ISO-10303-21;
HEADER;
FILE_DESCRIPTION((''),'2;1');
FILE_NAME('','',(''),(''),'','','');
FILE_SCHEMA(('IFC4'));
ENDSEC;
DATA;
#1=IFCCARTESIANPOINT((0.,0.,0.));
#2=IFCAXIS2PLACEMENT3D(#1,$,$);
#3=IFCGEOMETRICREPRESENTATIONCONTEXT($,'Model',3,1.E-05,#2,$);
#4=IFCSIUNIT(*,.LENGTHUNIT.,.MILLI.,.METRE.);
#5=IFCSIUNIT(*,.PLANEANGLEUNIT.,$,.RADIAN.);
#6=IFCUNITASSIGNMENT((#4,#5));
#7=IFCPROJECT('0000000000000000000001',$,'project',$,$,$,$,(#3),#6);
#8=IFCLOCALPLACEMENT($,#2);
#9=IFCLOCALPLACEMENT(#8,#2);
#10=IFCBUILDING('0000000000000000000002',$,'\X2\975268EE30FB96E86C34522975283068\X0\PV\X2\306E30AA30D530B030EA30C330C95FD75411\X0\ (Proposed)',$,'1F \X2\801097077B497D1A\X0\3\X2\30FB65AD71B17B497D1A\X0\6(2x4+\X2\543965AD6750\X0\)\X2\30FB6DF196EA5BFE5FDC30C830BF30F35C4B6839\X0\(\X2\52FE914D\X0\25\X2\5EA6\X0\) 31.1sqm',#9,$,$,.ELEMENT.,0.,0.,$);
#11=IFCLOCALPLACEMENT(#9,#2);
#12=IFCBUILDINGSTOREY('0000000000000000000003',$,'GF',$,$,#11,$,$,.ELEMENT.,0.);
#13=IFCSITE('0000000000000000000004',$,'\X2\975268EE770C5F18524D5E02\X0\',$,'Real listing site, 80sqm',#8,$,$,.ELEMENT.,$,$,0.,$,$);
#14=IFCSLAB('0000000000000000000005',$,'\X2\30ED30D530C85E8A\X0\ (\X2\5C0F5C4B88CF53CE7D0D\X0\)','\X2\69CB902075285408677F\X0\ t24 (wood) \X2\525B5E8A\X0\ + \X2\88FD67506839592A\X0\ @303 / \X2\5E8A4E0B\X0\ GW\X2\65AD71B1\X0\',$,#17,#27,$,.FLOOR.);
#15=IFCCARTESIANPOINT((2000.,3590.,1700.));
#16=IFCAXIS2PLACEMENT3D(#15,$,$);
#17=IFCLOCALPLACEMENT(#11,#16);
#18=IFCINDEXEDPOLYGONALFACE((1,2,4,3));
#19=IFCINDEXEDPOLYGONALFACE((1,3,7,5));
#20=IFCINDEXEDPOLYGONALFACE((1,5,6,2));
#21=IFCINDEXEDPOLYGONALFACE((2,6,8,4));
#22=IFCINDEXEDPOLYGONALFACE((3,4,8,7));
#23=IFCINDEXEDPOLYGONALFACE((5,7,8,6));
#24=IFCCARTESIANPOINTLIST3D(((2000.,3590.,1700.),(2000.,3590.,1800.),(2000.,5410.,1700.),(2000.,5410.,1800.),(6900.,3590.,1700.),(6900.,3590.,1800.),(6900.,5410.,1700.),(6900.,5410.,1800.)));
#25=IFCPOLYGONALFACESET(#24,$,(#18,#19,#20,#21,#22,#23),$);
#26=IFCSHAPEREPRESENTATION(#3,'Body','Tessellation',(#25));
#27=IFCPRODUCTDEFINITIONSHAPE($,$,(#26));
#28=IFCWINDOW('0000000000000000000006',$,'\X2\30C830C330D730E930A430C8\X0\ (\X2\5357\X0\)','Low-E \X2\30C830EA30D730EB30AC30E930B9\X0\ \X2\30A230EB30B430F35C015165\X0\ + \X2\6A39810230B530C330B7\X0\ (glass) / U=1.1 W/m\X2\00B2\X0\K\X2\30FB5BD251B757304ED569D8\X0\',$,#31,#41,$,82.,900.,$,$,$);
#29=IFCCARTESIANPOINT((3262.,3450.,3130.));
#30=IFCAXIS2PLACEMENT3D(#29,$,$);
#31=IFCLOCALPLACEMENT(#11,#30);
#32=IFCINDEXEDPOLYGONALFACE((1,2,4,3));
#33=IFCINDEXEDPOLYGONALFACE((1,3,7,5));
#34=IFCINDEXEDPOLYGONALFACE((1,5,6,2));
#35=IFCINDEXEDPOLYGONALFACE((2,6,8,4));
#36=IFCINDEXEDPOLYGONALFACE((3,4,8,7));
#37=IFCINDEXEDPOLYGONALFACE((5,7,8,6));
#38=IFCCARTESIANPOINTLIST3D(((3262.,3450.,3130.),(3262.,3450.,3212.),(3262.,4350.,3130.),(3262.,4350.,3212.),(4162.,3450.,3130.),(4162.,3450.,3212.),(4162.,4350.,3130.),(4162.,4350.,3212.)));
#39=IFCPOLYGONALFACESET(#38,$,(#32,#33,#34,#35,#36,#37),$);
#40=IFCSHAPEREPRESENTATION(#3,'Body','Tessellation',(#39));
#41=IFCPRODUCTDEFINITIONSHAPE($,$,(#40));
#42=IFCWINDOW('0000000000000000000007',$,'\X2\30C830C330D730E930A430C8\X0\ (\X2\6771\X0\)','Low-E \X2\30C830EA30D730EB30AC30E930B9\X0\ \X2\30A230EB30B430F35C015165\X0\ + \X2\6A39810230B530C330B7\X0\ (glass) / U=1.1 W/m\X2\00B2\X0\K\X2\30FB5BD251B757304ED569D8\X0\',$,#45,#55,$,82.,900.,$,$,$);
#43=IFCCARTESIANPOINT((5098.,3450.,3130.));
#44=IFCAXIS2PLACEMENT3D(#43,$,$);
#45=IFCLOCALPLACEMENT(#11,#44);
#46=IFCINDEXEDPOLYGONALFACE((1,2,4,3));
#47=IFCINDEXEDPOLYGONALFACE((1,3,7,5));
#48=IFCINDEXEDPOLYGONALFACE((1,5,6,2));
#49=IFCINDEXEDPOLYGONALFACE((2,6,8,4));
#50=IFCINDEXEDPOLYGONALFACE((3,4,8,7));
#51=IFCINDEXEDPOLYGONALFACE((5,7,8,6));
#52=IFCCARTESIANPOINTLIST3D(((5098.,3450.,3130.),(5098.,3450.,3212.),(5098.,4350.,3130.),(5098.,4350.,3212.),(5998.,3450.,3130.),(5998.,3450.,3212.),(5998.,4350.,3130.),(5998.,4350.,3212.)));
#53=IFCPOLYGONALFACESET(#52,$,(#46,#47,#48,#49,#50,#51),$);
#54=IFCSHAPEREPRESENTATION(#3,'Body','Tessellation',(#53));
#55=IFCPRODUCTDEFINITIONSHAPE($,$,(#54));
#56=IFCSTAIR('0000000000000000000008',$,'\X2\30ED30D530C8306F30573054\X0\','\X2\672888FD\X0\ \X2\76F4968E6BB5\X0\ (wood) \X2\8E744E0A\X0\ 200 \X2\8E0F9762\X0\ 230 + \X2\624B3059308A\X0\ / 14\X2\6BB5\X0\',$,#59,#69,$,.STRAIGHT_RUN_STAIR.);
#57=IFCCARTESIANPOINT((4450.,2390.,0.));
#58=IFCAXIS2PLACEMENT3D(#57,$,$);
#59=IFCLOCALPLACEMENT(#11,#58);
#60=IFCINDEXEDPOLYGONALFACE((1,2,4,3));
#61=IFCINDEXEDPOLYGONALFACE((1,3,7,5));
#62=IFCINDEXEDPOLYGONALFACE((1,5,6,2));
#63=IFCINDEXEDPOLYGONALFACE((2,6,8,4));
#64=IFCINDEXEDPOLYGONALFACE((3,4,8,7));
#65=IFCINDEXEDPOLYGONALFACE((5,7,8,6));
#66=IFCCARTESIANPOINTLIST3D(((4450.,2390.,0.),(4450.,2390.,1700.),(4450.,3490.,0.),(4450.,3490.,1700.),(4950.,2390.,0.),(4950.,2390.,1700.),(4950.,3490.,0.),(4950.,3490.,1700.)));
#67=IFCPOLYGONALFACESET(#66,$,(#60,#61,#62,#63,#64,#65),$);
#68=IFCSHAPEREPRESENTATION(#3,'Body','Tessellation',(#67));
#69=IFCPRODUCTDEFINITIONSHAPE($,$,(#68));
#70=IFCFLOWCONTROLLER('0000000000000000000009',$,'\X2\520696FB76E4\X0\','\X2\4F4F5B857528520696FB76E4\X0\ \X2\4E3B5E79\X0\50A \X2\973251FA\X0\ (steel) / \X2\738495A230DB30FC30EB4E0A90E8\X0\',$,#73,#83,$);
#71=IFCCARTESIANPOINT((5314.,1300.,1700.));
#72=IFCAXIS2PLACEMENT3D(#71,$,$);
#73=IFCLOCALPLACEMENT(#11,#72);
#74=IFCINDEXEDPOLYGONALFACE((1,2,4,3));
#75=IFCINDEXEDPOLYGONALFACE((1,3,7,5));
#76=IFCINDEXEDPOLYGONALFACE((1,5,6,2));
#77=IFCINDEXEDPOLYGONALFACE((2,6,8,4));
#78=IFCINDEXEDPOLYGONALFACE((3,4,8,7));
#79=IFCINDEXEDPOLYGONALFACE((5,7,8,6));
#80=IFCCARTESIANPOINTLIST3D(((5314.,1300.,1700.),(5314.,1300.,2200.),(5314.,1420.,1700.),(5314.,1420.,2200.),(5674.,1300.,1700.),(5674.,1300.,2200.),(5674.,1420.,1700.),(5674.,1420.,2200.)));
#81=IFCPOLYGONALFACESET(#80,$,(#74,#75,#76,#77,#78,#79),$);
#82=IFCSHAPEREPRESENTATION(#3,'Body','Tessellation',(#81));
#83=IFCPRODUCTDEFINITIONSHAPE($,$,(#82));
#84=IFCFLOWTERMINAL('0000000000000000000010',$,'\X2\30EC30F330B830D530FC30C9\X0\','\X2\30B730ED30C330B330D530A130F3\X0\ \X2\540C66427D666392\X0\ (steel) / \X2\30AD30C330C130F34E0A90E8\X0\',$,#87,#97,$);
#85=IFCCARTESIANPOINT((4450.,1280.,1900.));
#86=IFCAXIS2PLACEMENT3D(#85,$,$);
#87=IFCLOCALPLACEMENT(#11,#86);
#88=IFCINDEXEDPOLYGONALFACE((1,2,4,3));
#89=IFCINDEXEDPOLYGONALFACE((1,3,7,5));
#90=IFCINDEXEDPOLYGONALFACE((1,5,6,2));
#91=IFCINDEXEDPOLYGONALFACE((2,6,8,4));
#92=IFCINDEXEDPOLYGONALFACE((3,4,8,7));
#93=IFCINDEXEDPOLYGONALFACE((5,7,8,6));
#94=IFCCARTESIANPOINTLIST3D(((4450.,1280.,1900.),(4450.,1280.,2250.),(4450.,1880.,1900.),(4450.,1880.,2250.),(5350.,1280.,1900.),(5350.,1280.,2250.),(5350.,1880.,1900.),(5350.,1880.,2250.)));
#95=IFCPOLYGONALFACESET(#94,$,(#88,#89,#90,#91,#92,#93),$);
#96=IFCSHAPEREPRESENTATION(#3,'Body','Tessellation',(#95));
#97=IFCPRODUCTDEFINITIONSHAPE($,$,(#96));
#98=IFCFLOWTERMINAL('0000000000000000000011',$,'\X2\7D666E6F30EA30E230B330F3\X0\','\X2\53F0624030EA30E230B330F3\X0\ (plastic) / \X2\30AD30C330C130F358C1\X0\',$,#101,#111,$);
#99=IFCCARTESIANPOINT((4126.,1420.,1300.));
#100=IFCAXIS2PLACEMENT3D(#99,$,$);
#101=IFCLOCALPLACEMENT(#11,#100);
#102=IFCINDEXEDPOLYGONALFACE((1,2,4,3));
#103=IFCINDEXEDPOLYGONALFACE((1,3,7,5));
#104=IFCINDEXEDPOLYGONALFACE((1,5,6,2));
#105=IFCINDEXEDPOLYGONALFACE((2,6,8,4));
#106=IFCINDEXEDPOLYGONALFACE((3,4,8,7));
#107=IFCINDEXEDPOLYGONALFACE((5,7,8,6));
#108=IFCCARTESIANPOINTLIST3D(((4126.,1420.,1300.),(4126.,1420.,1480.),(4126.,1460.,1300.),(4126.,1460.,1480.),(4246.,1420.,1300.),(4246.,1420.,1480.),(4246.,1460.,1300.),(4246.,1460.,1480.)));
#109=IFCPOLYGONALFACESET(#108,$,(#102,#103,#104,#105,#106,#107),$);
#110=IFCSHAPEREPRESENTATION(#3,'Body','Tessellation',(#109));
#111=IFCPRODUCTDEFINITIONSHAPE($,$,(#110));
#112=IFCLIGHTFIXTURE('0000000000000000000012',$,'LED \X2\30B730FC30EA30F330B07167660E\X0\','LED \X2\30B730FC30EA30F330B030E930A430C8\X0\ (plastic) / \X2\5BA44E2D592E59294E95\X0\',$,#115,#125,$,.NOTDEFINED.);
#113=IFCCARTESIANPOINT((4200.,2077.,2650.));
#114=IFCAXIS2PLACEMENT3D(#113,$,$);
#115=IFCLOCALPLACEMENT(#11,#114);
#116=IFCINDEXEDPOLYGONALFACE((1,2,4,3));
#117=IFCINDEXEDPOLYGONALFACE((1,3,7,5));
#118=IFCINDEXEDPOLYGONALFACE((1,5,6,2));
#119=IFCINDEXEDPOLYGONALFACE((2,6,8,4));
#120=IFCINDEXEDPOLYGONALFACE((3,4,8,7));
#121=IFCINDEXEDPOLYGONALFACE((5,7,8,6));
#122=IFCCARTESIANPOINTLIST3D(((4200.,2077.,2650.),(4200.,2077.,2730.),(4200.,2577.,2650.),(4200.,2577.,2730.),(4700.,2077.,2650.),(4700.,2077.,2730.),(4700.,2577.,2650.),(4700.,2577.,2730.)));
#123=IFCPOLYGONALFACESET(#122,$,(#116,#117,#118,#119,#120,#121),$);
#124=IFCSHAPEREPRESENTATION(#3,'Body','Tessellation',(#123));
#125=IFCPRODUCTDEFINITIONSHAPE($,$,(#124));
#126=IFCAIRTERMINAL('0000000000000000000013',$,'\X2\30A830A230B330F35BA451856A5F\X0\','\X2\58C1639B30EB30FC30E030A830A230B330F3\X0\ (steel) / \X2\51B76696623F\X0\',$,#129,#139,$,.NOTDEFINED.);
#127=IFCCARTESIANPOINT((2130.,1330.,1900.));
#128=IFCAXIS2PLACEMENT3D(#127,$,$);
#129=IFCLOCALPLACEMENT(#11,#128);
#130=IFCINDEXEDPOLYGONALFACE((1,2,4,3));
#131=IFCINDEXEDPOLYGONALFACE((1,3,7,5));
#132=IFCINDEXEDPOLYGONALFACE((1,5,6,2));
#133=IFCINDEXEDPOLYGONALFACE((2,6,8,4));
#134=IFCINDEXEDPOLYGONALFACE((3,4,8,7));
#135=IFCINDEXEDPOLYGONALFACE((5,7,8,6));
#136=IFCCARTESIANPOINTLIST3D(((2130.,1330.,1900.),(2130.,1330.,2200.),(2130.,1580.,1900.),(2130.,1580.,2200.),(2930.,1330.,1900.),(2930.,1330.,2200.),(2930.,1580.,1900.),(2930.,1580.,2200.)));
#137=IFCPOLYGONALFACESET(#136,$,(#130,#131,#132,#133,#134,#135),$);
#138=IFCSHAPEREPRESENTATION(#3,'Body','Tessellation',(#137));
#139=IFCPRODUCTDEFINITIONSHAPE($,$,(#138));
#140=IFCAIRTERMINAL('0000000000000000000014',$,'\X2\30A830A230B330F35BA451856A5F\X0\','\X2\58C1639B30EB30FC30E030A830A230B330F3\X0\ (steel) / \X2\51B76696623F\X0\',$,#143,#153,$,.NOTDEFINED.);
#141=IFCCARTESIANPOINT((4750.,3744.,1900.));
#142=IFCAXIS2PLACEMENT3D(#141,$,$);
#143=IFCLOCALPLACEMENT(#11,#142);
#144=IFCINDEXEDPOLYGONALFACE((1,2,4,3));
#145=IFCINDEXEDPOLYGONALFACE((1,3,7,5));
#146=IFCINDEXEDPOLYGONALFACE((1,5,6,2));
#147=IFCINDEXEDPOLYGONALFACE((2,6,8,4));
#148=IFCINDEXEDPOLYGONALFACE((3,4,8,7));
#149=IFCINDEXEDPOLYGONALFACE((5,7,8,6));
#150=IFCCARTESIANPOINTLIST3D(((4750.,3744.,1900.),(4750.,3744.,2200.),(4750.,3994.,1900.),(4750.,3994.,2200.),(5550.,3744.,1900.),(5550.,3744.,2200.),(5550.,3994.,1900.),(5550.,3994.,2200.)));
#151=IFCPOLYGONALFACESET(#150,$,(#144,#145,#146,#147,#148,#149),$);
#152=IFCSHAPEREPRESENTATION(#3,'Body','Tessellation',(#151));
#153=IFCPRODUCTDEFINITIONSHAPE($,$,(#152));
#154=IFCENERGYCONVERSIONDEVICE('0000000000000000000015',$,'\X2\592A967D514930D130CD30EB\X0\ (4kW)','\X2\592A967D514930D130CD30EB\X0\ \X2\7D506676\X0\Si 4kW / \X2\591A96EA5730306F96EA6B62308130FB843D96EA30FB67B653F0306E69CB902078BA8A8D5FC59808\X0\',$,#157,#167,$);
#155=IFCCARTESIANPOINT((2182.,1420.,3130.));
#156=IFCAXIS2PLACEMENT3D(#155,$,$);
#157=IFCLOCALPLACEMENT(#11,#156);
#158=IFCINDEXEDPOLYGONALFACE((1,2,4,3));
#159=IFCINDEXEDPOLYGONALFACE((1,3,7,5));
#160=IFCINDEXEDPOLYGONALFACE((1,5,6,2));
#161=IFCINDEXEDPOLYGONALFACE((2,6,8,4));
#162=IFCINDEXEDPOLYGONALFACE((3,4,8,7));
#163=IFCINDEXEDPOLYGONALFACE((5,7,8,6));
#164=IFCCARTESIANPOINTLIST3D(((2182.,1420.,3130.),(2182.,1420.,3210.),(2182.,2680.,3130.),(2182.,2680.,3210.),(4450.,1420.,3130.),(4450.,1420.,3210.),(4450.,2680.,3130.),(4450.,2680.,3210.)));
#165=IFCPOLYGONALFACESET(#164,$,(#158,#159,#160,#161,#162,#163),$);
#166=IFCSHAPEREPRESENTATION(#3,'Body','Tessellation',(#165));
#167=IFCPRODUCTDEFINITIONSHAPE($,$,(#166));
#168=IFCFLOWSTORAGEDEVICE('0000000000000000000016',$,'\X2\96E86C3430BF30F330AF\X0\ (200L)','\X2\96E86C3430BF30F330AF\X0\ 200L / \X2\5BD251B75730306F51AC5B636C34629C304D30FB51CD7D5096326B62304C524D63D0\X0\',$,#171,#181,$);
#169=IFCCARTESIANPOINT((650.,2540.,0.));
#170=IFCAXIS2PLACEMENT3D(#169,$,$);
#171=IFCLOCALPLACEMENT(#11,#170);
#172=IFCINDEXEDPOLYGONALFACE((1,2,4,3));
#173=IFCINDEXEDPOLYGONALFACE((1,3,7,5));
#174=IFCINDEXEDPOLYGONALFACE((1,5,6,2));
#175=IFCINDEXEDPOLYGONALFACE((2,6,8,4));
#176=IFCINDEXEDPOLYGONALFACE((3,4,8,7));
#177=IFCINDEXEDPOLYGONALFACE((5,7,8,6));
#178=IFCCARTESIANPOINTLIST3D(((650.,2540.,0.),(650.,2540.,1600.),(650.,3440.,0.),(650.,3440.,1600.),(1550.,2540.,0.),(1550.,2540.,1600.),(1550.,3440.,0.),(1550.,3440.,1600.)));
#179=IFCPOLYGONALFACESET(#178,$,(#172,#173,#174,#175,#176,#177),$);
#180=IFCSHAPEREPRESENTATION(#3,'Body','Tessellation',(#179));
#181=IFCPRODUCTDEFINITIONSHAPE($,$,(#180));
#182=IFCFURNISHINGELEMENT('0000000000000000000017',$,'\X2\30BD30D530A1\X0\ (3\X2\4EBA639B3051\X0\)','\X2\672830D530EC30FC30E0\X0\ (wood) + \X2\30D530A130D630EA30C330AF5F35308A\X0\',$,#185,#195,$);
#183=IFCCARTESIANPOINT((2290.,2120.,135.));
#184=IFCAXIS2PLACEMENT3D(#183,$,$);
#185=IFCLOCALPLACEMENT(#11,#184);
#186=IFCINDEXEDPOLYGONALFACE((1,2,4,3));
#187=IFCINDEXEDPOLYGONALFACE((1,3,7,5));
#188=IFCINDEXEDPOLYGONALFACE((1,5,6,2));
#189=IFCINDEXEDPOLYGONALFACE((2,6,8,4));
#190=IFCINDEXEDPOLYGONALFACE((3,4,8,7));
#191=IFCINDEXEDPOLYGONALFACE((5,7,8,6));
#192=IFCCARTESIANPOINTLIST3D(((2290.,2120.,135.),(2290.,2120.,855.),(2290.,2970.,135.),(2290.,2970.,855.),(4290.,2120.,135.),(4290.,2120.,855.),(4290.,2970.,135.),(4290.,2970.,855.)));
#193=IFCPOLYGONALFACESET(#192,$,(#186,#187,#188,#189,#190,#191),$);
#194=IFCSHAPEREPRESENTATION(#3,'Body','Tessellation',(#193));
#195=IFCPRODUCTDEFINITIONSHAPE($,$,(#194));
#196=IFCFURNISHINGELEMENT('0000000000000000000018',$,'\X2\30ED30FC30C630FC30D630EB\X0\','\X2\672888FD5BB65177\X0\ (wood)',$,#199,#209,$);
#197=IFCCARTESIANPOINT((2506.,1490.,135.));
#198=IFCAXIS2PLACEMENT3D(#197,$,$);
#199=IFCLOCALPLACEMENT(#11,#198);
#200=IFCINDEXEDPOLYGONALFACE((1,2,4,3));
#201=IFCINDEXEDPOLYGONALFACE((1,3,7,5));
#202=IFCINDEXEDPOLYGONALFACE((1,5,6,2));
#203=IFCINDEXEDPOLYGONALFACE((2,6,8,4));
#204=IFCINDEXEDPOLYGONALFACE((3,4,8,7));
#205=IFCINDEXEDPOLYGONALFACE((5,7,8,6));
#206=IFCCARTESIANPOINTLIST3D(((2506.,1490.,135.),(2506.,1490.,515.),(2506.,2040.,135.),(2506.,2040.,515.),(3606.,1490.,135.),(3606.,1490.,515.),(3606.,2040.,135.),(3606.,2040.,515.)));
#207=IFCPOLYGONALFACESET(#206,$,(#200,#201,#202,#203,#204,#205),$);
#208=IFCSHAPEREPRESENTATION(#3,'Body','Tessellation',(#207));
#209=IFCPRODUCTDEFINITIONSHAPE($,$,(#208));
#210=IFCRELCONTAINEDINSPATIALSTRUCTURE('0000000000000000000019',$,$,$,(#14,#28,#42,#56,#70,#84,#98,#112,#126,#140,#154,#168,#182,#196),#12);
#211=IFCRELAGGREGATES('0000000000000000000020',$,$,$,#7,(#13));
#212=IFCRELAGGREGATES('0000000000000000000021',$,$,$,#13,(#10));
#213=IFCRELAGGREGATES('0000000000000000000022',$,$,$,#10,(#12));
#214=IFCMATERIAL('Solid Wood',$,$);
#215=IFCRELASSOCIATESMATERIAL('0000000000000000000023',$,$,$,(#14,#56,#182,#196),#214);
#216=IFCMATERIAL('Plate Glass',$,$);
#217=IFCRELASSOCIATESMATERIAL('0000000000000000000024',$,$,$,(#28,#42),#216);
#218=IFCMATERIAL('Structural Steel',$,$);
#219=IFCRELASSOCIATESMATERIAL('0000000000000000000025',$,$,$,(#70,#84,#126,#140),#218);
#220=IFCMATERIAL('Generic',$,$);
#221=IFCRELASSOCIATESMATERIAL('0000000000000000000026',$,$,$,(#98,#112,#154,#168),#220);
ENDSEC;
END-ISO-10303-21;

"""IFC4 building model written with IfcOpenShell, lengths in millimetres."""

from ifc_helpers import new_model, si_unit, frame, frame_2d, origin, place, context, project, spatial, rectangle, extrude, material, element, save


model = new_model("IFC4")

# Units and contexts
model_context = context("Model", 3, precision=1e-05, world=origin())
ifc_project = project(units=[si_unit("LENGTHUNIT", "METRE", prefix="MILLI"), si_unit("PLANEANGLEUNIT", "RADIAN")], contexts=[model_context])

# Site, building, storey
site_placement = place(None, origin())
site = spatial("IfcSite", under=ifc_project, at=site_placement, Name="青森県弘前市", ObjectType="Real listing site, 80sqm", CompositionType="ELEMENT", RefElevation=0.0)
building_placement = place(site_placement, origin())
building = spatial("IfcBuilding", under=site, at=building_placement, Name="青森・雨水利用とPVのオフグリッド志向 (Proposed)", ObjectType="1F 耐震等級3・断熱等級6(2x4+吹断材)・深雪対応トタン屋根(勾配25度) 31.1sqm", CompositionType="ELEMENT", ElevationOfRefHeight=0.0, ElevationOfTerrain=0.0)
storey_placement = place(building_placement, origin())
storey = spatial("IfcBuildingStorey", under=building, at=storey_placement, Name="GF", CompositionType="ELEMENT", Elevation=0.0)

# Shared definitions
ifc_material_1 = material(Name="Solid Wood")

# Slab
slab_placement = place(storey_placement, frame((2000.0, 3590.0, 1700.0)))
element("IfcSlab", 1, at=slab_placement, inside=storey, material=ifc_material_1, Name="ロフト床 (小屋裏収納)", Description="構造用合板 t24 (wood) 剛床 + 製材根太 @303 / 床下 GW断熱", PredefinedType="FLOOR", context=model_context, shape_type="SweptSolid", body=[
    extrude(rectangle(XDim=4900.0, YDim=1820.0, at=frame_2d((2450.0, 910.0))), frame((2000.0, 3590.0, 1700.0)), (0.0, 0.0, 1.0), 100.0),
])

# Windows
ifc_material_2 = material(Name="Plate Glass")
window_1_placement = place(storey_placement, frame((3262.0, 3450.0, 3130.0)))
element("IfcWindow", 2, at=window_1_placement, inside=storey, material=ifc_material_2, Name="トップライト (南)", Description="Low-E トリプルガラス アルゴン封入 + 樹脂サッシ (glass) / U=1.1 W/m²K・寒冷地仕様", OverallHeight=82.0, OverallWidth=900.0, context=model_context, shape_type="SweptSolid", body=[
    extrude(rectangle(XDim=900.0, YDim=900.0, at=frame_2d((450.0, 450.0))), frame((3262.0, 3450.0, 3130.0)), (0.0, 0.0, 1.0), 82.0),
])
window_2_placement = place(storey_placement, frame((5098.0, 3450.0, 3130.0)))
element("IfcWindow", 3, at=window_2_placement, inside=storey, material=ifc_material_2, Name="トップライト (東)", Description="Low-E トリプルガラス アルゴン封入 + 樹脂サッシ (glass) / U=1.1 W/m²K・寒冷地仕様", OverallHeight=82.0, OverallWidth=900.0, context=model_context, shape_type="SweptSolid", body=[
    extrude(rectangle(XDim=900.0, YDim=900.0, at=frame_2d((450.0, 450.0))), frame((5098.0, 3450.0, 3130.0)), (0.0, 0.0, 1.0), 82.0),
])

# Stair
stair_placement = place(storey_placement, frame((4450.0, 2390.0, 0.0)))
element("IfcStair", 4, at=stair_placement, inside=storey, material=ifc_material_1, Name="ロフトはしご", Description="木製 直階段 (wood) 蹴上 200 踏面 230 + 手すり / 14段", PredefinedType="STRAIGHT_RUN_STAIR", context=model_context, shape_type="SweptSolid", body=[
    extrude(rectangle(XDim=500.0, YDim=1100.0, at=frame_2d((250.0, 550.0))), frame((4450.0, 2390.0, 0.0)), (0.0, 0.0, 1.0), 1700.0),
])

# Flow controller
ifc_material_3 = material(Name="Structural Steel")
flow_controller_placement = place(storey_placement, frame((5314.0, 1300.0, 1700.0)))
element("IfcFlowController", 5, at=flow_controller_placement, inside=storey, material=ifc_material_3, Name="分電盤", Description="住宅用分電盤 主幹50A 露出 (steel) / 玄関ホール上部", context=model_context, shape_type="SweptSolid", body=[
    extrude(rectangle(XDim=360.0, YDim=120.0, at=frame_2d((180.0, 60.0))), frame((5314.0, 1300.0, 1700.0)), (0.0, 0.0, 1.0), 500.0),
])

# Flow terminals
flow_terminal_1_placement = place(storey_placement, frame((4450.0, 1280.0, 1900.0)))
element("IfcFlowTerminal", 6, at=flow_terminal_1_placement, inside=storey, material=ifc_material_3, Name="レンジフード", Description="シロッコファン 同時給排 (steel) / キッチン上部", context=model_context, shape_type="SweptSolid", body=[
    extrude(rectangle(XDim=900.0, YDim=600.0, at=frame_2d((450.0, 300.0))), frame((4450.0, 1280.0, 1900.0)), (0.0, 0.0, 1.0), 350.0),
])
ifc_material_4 = material(Name="Generic")
flow_terminal_2_placement = place(storey_placement, frame((4126.0, 1420.0, 1300.0)))
element("IfcFlowTerminal", 7, at=flow_terminal_2_placement, inside=storey, material=ifc_material_4, Name="給湯リモコン", Description="台所リモコン (plastic) / キッチン壁", context=model_context, shape_type="SweptSolid", body=[
    extrude(rectangle(XDim=120.0, YDim=40.0, at=frame_2d((60.0, 20.0))), frame((4126.0, 1420.0, 1300.0)), (0.0, 0.0, 1.0), 180.0),
])

# Light fixture
light_fixture_placement = place(storey_placement, frame((4200.0, 2077.0, 2650.0)))
element("IfcLightFixture", 8, at=light_fixture_placement, inside=storey, material=ifc_material_4, Name="LED シーリング照明", Description="LED シーリングライト (plastic) / 室中央天井", PredefinedType="NOTDEFINED", context=model_context, shape_type="SweptSolid", body=[
    extrude(rectangle(XDim=500.0, YDim=500.0, at=frame_2d((250.0, 250.0))), frame((4200.0, 2077.0, 2650.0)), (0.0, 0.0, 1.0), 80.0),
])

# Air terminals
air_terminal_1_placement = place(storey_placement, frame((2130.0, 1330.0, 1900.0)))
element("IfcAirTerminal", 9, at=air_terminal_1_placement, inside=storey, material=ifc_material_3, Name="エアコン室内機", Description="壁掛ルームエアコン (steel) / 冷暖房", PredefinedType="NOTDEFINED", context=model_context, shape_type="SweptSolid", body=[
    extrude(rectangle(XDim=800.0, YDim=250.0, at=frame_2d((400.0, 125.0))), frame((2130.0, 1330.0, 1900.0)), (0.0, 0.0, 1.0), 300.0),
])
air_terminal_2_placement = place(storey_placement, frame((4750.0, 3744.0, 1900.0)))
element("IfcAirTerminal", 10, at=air_terminal_2_placement, inside=storey, material=ifc_material_3, Name="エアコン室内機", Description="壁掛ルームエアコン (steel) / 冷暖房", PredefinedType="NOTDEFINED", context=model_context, shape_type="SweptSolid", body=[
    extrude(rectangle(XDim=800.0, YDim=250.0, at=frame_2d((400.0, 125.0))), frame((4750.0, 3744.0, 1900.0)), (0.0, 0.0, 1.0), 300.0),
])

# Energy conversion device
energy_conversion_device_placement = place(storey_placement, frame((2182.0, 1420.0, 3130.0)))
element("IfcEnergyConversionDevice", 11, at=energy_conversion_device_placement, inside=storey, material=ifc_material_4, Name="太陽光パネル (4kW)", Description="太陽光パネル 結晶Si 4kW / 多雪地は雪止め・落雪・架台の構造確認必須", context=model_context, shape_type="SweptSolid", body=[
    extrude(rectangle(XDim=2268.0, YDim=1260.0, at=frame_2d((1134.0, 630.0))), frame((2182.0, 1420.0, 3130.0)), (0.0, 0.0, 1.0), 80.0),
])

# Flow storage device
flow_storage_device_placement = place(storey_placement, frame((650.0, 2540.0, 0.0)))
element("IfcFlowStorageDevice", 12, at=flow_storage_device_placement, inside=storey, material=ifc_material_4, Name="雨水タンク (200L)", Description="雨水タンク 200L / 寒冷地は冬季水抜き・凍結防止が前提", context=model_context, shape_type="SweptSolid", body=[
    extrude(rectangle(XDim=900.0, YDim=900.0, at=frame_2d((450.0, 450.0))), frame((650.0, 2540.0, 0.0)), (0.0, 0.0, 1.0), 1600.0),
])

# Furnishing elements
furnishing_1_placement = place(storey_placement, frame((2290.0, 2120.0, 135.0)))
element("IfcFurnishingElement", 13, at=furnishing_1_placement, inside=storey, material=ifc_material_1, Name="ソファ (3人掛け)", Description="木フレーム (wood) + ファブリック張り", context=model_context, shape_type="SweptSolid", body=[
    extrude(rectangle(XDim=2000.0, YDim=850.0, at=frame_2d((1000.0, 425.0))), frame((2290.0, 2120.0, 135.0)), (0.0, 0.0, 1.0), 720.0),
])
furnishing_2_placement = place(storey_placement, frame((2506.0, 1490.0, 135.0)))
element("IfcFurnishingElement", 14, at=furnishing_2_placement, inside=storey, material=ifc_material_1, Name="ローテーブル", Description="木製家具 (wood)", context=model_context, shape_type="SweptSolid", body=[
    extrude(rectangle(XDim=1100.0, YDim=550.0, at=frame_2d((550.0, 275.0))), frame((2506.0, 1490.0, 135.0)), (0.0, 0.0, 1.0), 380.0),
])

save(model, "model.ifc")
